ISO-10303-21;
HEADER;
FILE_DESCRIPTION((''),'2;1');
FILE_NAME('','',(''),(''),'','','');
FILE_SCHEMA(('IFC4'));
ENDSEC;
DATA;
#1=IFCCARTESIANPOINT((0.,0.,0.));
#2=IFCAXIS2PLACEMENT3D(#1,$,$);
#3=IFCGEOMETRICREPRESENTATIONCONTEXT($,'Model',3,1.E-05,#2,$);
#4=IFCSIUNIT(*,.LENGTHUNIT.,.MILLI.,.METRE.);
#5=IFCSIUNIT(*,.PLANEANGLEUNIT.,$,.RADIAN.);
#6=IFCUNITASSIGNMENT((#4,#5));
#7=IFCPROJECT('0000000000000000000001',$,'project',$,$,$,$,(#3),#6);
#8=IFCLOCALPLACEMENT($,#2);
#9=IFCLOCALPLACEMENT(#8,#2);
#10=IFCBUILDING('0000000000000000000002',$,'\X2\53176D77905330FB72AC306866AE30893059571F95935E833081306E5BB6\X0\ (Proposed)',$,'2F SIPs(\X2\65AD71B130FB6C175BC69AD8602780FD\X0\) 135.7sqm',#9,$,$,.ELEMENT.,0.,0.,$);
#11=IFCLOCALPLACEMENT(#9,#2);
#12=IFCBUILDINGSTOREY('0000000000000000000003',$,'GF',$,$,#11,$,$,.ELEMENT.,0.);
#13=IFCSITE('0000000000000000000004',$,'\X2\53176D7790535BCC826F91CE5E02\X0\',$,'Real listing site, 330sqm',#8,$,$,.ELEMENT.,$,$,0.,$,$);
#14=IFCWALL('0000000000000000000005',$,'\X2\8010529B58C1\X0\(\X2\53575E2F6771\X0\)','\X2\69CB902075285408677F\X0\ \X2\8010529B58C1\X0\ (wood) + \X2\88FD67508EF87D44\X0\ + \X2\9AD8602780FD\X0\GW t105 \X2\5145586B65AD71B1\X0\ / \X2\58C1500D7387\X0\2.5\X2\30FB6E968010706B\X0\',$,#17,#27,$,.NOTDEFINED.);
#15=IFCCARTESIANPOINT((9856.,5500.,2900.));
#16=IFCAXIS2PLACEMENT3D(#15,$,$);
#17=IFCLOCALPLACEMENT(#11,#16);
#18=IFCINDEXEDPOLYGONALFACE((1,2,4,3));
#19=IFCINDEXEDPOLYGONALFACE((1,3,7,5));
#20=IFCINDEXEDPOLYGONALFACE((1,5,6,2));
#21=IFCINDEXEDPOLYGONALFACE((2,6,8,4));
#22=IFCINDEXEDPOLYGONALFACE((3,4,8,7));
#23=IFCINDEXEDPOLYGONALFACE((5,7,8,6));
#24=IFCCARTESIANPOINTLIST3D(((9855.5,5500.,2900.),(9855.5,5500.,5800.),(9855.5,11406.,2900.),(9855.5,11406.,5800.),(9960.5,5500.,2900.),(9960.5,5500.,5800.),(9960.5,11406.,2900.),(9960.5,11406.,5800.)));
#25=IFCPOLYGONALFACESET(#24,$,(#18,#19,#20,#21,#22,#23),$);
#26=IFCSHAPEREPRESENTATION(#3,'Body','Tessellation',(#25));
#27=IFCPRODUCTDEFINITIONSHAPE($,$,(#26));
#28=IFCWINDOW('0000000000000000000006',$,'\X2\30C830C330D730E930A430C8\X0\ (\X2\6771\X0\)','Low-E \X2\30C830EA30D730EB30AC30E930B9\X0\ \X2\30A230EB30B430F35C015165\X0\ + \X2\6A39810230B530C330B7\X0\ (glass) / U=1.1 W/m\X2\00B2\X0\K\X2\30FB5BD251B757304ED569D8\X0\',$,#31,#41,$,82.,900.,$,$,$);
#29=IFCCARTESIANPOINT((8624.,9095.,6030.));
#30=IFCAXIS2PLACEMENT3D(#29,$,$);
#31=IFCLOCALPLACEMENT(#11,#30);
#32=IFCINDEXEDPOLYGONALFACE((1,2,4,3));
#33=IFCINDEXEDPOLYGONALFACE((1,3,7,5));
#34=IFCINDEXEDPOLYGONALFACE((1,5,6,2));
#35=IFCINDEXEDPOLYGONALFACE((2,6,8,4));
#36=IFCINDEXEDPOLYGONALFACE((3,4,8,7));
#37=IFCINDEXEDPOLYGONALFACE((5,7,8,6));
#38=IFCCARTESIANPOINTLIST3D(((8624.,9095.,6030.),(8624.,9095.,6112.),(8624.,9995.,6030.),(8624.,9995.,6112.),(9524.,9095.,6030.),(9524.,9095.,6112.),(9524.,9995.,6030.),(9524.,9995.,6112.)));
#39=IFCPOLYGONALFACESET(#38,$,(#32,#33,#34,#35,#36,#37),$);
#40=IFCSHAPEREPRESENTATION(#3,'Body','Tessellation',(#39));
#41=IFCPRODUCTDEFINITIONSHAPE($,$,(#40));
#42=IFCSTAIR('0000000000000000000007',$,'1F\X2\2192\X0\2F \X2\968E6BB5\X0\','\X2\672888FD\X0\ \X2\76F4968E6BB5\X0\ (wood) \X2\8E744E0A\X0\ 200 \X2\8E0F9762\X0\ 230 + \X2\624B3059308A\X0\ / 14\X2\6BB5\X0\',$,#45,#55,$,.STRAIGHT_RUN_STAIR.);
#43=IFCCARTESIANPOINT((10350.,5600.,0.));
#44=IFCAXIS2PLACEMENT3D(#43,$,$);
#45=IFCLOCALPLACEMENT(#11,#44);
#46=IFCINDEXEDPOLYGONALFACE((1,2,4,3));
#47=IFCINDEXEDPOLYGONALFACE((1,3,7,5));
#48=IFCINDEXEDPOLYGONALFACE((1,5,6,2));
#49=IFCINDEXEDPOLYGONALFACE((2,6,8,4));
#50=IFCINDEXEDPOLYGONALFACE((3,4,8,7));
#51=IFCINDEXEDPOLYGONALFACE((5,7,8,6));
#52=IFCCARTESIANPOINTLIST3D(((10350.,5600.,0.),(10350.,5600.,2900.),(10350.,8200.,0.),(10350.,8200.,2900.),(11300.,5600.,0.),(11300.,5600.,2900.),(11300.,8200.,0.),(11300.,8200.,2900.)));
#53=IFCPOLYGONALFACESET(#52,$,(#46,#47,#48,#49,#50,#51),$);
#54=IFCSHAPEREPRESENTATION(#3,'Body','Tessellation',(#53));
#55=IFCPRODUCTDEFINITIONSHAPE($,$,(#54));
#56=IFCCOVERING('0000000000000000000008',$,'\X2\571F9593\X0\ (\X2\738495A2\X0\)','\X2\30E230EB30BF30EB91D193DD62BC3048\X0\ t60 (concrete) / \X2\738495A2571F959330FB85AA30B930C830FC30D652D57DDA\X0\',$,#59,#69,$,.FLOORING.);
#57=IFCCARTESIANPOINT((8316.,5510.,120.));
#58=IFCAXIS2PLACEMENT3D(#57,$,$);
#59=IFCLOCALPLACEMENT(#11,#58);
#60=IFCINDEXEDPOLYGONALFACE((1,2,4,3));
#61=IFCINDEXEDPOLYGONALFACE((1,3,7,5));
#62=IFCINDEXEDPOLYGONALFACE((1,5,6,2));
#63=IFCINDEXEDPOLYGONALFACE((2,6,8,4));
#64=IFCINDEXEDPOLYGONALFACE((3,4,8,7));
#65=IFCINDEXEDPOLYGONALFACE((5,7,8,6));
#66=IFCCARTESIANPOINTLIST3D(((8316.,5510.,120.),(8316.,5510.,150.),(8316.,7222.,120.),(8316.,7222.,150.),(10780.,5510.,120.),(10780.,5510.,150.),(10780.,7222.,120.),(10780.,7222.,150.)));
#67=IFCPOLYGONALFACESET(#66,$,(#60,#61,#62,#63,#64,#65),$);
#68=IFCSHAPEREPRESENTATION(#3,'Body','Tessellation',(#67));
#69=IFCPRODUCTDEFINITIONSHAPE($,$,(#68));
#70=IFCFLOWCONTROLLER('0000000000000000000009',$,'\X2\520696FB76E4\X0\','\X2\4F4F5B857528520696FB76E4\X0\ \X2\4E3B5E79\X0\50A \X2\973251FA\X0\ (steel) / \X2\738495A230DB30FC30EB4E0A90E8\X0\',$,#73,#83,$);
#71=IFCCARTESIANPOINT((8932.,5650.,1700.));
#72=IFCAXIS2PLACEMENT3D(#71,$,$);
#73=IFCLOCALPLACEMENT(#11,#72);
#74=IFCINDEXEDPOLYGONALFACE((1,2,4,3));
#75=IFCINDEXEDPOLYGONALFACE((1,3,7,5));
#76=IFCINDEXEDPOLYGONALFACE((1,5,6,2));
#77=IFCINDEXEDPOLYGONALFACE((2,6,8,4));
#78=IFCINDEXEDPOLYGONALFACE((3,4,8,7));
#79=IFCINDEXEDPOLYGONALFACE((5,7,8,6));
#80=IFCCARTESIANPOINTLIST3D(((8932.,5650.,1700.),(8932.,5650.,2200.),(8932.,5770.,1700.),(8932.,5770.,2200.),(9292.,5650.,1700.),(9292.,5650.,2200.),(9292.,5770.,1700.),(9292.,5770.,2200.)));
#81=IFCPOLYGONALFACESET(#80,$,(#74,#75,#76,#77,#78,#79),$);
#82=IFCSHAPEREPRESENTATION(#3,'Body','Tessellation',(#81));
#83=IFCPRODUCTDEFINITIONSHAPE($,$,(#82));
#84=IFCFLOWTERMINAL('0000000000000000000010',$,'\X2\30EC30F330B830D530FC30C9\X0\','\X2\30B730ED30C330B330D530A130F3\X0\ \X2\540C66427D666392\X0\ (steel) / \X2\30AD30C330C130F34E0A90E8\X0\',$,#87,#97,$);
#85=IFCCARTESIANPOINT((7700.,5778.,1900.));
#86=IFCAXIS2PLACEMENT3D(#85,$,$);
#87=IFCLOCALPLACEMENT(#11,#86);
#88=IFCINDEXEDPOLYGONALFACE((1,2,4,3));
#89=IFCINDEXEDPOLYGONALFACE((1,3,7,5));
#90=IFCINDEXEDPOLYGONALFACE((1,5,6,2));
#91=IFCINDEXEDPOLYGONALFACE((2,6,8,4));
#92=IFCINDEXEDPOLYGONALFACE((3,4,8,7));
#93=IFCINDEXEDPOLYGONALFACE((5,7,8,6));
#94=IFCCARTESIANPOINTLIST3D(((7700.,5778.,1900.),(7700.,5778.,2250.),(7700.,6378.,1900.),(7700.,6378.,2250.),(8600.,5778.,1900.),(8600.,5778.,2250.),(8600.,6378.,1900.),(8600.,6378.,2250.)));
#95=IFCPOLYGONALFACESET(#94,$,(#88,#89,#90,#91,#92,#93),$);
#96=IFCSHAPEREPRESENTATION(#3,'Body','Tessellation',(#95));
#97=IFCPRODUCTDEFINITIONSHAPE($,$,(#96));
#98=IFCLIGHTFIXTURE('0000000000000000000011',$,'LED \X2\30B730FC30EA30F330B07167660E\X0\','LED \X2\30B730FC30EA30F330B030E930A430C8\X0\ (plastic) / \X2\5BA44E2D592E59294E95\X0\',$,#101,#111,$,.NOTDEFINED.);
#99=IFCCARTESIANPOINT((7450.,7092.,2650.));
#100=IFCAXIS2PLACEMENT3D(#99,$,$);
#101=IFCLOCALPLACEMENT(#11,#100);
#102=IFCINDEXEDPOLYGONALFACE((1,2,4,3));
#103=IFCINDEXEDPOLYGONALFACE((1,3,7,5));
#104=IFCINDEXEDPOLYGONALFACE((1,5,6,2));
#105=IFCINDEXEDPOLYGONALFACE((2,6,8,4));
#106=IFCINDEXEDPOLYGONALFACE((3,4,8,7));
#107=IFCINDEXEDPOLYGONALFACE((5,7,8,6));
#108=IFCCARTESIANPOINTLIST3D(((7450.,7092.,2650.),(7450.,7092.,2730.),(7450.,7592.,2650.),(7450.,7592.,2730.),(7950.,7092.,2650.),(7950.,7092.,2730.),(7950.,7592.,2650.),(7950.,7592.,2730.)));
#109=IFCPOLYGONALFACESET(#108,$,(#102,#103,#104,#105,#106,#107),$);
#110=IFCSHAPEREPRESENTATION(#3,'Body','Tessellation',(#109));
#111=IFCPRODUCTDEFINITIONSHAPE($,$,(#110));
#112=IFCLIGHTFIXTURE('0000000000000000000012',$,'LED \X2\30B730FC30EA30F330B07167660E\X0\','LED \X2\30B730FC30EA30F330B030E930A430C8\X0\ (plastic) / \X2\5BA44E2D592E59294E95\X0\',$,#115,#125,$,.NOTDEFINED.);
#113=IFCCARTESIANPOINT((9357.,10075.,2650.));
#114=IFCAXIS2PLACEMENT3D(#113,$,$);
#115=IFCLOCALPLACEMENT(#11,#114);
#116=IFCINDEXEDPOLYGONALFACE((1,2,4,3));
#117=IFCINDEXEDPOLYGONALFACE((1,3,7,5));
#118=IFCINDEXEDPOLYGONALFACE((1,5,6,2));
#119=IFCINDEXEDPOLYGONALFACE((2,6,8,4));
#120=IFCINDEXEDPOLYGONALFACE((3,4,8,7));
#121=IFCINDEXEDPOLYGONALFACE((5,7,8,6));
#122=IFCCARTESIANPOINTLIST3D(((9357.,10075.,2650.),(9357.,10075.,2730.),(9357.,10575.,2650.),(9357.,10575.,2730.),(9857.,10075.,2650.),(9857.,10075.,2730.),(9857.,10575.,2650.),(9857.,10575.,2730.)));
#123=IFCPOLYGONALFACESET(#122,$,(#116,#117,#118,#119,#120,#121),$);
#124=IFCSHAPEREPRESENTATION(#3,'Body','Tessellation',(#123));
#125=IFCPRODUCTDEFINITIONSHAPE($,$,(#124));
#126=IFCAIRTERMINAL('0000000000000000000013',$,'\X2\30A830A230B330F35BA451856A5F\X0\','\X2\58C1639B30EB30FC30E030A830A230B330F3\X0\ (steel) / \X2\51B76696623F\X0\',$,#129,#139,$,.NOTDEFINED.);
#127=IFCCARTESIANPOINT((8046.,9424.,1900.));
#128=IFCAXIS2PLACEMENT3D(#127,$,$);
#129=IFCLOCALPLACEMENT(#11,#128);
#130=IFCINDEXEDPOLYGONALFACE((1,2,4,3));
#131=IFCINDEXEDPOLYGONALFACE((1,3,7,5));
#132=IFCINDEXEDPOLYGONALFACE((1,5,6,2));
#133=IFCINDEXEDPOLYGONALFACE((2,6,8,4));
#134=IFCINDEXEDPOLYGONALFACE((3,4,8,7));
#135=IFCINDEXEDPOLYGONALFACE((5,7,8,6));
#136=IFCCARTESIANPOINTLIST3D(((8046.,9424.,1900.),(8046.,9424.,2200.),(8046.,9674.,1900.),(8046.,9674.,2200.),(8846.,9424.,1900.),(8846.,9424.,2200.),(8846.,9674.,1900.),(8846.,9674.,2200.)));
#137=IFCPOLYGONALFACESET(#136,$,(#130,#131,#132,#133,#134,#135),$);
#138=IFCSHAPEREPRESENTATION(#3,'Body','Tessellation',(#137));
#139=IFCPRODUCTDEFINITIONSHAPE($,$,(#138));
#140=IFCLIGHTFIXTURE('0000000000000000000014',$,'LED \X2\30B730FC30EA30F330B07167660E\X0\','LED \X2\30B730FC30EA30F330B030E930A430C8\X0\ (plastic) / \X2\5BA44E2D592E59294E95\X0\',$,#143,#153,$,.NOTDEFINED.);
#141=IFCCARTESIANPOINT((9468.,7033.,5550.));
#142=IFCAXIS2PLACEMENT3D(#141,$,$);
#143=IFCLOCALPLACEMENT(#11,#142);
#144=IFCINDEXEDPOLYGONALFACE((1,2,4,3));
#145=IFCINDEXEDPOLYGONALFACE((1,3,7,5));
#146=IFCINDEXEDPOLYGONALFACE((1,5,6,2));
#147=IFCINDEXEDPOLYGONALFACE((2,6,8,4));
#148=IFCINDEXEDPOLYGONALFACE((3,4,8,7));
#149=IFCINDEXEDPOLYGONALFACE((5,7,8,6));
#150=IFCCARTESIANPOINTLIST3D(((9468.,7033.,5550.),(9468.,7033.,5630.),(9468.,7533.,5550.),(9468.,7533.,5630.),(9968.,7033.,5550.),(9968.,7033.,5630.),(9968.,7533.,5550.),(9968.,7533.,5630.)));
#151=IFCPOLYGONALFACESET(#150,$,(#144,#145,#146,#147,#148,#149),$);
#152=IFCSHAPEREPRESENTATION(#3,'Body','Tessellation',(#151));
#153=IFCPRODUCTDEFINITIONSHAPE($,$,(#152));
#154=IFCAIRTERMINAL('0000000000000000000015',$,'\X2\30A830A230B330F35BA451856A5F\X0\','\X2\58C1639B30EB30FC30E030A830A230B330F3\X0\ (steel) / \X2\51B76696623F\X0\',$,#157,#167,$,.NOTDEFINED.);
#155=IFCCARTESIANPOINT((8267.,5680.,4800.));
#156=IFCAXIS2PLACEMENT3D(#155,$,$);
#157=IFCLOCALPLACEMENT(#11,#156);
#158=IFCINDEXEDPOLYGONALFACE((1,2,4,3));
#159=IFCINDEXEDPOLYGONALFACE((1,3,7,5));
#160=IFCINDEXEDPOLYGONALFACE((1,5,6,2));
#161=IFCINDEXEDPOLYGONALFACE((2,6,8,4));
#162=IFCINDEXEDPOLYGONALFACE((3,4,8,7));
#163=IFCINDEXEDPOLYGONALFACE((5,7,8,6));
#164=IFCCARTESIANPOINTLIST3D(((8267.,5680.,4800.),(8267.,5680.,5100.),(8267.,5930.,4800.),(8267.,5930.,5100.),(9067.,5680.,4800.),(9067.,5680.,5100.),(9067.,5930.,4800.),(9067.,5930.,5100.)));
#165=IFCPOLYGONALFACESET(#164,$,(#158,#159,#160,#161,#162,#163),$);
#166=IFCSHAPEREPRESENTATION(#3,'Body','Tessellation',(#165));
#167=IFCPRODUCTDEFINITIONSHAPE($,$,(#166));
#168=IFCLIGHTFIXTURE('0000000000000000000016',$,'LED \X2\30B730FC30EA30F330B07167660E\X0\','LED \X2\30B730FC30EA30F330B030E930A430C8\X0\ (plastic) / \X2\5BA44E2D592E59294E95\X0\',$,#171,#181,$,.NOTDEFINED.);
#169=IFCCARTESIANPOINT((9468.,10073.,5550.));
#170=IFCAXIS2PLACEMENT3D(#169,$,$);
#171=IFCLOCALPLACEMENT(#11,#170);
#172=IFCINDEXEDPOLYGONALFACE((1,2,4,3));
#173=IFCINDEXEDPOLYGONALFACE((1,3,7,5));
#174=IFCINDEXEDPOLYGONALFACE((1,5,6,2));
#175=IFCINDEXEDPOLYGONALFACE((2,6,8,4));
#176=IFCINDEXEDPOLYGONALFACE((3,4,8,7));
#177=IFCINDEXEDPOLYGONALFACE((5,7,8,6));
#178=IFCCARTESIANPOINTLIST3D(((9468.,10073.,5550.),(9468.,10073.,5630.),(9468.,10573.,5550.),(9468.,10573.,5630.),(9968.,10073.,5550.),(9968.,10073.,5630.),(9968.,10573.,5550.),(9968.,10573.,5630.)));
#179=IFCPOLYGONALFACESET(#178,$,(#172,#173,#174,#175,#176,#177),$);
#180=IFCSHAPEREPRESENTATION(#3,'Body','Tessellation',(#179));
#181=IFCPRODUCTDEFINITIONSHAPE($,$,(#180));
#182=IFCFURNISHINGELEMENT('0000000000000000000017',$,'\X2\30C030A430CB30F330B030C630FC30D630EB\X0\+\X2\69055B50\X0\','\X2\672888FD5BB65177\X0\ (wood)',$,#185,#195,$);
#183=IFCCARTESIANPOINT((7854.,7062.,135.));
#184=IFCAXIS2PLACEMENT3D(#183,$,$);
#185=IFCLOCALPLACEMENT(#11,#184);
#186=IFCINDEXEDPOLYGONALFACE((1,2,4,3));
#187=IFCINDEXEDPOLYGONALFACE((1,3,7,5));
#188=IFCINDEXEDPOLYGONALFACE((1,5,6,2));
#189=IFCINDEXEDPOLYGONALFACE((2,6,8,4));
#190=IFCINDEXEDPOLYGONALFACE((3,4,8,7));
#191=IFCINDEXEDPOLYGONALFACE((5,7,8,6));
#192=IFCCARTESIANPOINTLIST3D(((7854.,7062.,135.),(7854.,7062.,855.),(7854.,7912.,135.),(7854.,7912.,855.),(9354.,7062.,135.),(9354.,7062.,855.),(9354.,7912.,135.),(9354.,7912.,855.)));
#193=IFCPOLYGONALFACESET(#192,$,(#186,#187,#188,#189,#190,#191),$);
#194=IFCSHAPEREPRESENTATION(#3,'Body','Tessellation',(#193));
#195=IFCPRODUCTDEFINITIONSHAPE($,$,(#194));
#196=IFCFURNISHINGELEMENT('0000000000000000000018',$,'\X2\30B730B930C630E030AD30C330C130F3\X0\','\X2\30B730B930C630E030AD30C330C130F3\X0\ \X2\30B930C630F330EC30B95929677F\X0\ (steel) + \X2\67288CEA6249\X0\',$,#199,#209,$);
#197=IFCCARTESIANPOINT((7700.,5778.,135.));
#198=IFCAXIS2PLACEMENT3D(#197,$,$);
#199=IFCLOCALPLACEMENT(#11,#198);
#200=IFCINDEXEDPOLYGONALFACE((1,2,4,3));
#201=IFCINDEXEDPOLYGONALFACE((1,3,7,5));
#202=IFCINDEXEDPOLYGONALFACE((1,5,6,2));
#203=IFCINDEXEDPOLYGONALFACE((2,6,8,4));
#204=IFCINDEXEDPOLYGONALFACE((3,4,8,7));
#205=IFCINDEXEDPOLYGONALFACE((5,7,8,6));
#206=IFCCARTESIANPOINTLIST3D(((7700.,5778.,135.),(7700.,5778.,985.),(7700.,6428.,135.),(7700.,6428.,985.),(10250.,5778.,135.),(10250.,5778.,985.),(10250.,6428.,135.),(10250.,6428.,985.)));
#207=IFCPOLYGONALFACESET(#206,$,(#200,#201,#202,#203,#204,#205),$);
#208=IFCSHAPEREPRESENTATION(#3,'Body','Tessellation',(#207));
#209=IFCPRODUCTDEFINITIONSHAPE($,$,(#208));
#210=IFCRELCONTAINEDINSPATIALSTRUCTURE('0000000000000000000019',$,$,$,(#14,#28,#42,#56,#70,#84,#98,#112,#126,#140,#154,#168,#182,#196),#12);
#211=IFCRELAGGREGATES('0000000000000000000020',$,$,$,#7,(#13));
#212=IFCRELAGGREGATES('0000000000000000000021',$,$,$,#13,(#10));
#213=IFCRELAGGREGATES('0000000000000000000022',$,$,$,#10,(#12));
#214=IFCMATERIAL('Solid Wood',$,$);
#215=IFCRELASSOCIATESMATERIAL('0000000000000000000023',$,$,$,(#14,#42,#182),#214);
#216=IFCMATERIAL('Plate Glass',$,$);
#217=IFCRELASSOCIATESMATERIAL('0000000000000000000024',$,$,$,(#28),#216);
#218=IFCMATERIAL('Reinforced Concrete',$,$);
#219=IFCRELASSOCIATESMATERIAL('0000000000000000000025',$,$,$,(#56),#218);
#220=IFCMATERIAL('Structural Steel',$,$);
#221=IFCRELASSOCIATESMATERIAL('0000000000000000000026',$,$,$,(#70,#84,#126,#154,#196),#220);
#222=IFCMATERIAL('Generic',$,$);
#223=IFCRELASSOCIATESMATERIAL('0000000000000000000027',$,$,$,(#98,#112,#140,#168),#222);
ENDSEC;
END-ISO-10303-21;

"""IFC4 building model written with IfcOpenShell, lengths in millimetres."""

from ifc_helpers import new_model, si_unit, frame, frame_2d, origin, place, context, project, spatial, rectangle, extrude, material, element, save


model = new_model("IFC4")

# Units and contexts
model_context = context("Model", 3, precision=1e-05, world=origin())
ifc_project = project(units=[si_unit("LENGTHUNIT", "METRE", prefix="MILLI"), si_unit("PLANEANGLEUNIT", "RADIAN")], contexts=[model_context])

# Site, building, storey
site_placement = place(None, origin())
site = spatial("IfcSite", under=ifc_project, at=site_placement, Name="北海道富良野市", ObjectType="Real listing site, 330sqm", CompositionType="ELEMENT", RefElevation=0.0)
building_placement = place(site_placement, origin())
building = spatial("IfcBuilding", under=site, at=building_placement, Name="北海道・犬と暮らす土間広めの家 (Proposed)", ObjectType="2F SIPs(断熱・気密高性能) 135.7sqm", CompositionType="ELEMENT", ElevationOfRefHeight=0.0, ElevationOfTerrain=0.0)
storey_placement = place(building_placement, origin())
storey = spatial("IfcBuildingStorey", under=building, at=storey_placement, Name="GF", CompositionType="ELEMENT", Elevation=0.0)

# Shared definitions
ifc_material_1 = material(Name="Solid Wood")

# Wall
wall_1_placement = place(storey_placement, frame((9856.0, 5500.0, 2900.0)))
element("IfcWall", 1, at=wall_1_placement, inside=storey, material=ifc_material_1, Name="耐力壁(南帯東)", Description="構造用合板 耐力壁 (wood) + 製材軸組 + 高性能GW t105 充填断熱 / 壁倍率2.5・準耐火", PredefinedType="NOTDEFINED", context=model_context, shape_type="SweptSolid", body=[
    extrude(rectangle(XDim=105.0, YDim=5906.0, at=frame_2d((52.0, 2953.0))), frame((9856.0, 5500.0, 2900.0)), (0.0, 0.0, 1.0), 2900.0),
])

# Window
ifc_material_2 = material(Name="Plate Glass")
window_placement = place(storey_placement, frame((8624.0, 9095.0, 6030.0)))
element("IfcWindow", 2, at=window_placement, inside=storey, material=ifc_material_2, Name="トップライト (東)", Description="Low-E トリプルガラス アルゴン封入 + 樹脂サッシ (glass) / U=1.1 W/m²K・寒冷地仕様", OverallHeight=82.0, OverallWidth=900.0, context=model_context, shape_type="SweptSolid", body=[
    extrude(rectangle(XDim=900.0, YDim=900.0, at=frame_2d((450.0, 450.0))), frame((8624.0, 9095.0, 6030.0)), (0.0, 0.0, 1.0), 82.0),
])

# Stair
stair_placement = place(storey_placement, frame((10350.0, 5600.0, 0.0)))
element("IfcStair", 3, at=stair_placement, inside=storey, material=ifc_material_1, Name="1F→2F 階段", Description="木製 直階段 (wood) 蹴上 200 踏面 230 + 手すり / 14段", PredefinedType="STRAIGHT_RUN_STAIR", context=model_context, shape_type="SweptSolid", body=[
    extrude(rectangle(XDim=950.0, YDim=2600.0, at=frame_2d((475.0, 1300.0))), frame((10350.0, 5600.0, 0.0)), (0.0, 0.0, 1.0), 2900.0),
])

# Covering
ifc_material_3 = material(Name="Reinforced Concrete")
covering_placement = place(storey_placement, frame((8316.0, 5510.0, 120.0)))
element("IfcCovering", 4, at=covering_placement, inside=storey, material=ifc_material_3, Name="土間 (玄関)", Description="モルタル金鏝押え t60 (concrete) / 玄関土間・薪ストーブ動線", PredefinedType="FLOORING", context=model_context, shape_type="SweptSolid", body=[
    extrude(rectangle(XDim=2464.0, YDim=1712.0, at=frame_2d((1232.0, 856.0))), frame((8316.0, 5510.0, 120.0)), (0.0, 0.0, 1.0), 30.0),
])

# Flow controller
ifc_material_4 = material(Name="Structural Steel")
flow_controller_placement = place(storey_placement, frame((8932.0, 5650.0, 1700.0)))
element("IfcFlowController", 5, at=flow_controller_placement, inside=storey, material=ifc_material_4, Name="分電盤", Description="住宅用分電盤 主幹50A 露出 (steel) / 玄関ホール上部", context=model_context, shape_type="SweptSolid", body=[
    extrude(rectangle(XDim=360.0, YDim=120.0, at=frame_2d((180.0, 60.0))), frame((8932.0, 5650.0, 1700.0)), (0.0, 0.0, 1.0), 500.0),
])

# Flow terminal
flow_terminal_placement = place(storey_placement, frame((7700.0, 5778.0, 1900.0)))
element("IfcFlowTerminal", 6, at=flow_terminal_placement, inside=storey, material=ifc_material_4, Name="レンジフード", Description="シロッコファン 同時給排 (steel) / キッチン上部", context=model_context, shape_type="SweptSolid", body=[
    extrude(rectangle(XDim=900.0, YDim=600.0, at=frame_2d((450.0, 300.0))), frame((7700.0, 5778.0, 1900.0)), (0.0, 0.0, 1.0), 350.0),
])

# Light fixtures
ifc_material_5 = material(Name="Generic")
light_fixture_1_placement = place(storey_placement, frame((7450.0, 7092.0, 2650.0)))
element("IfcLightFixture", 7, at=light_fixture_1_placement, inside=storey, material=ifc_material_5, Name="LED シーリング照明", Description="LED シーリングライト (plastic) / 室中央天井", PredefinedType="NOTDEFINED", context=model_context, shape_type="SweptSolid", body=[
    extrude(rectangle(XDim=500.0, YDim=500.0, at=frame_2d((250.0, 250.0))), frame((7450.0, 7092.0, 2650.0)), (0.0, 0.0, 1.0), 80.0),
])
light_fixture_2_placement = place(storey_placement, frame((9357.0, 10075.0, 2650.0)))
element("IfcLightFixture", 8, at=light_fixture_2_placement, inside=storey, material=ifc_material_5, Name="LED シーリング照明", Description="LED シーリングライト (plastic) / 室中央天井", PredefinedType="NOTDEFINED", context=model_context, shape_type="SweptSolid", body=[
    extrude(rectangle(XDim=500.0, YDim=500.0, at=frame_2d((250.0, 250.0))), frame((9357.0, 10075.0, 2650.0)), (0.0, 0.0, 1.0), 80.0),
])

# Air terminal
air_terminal_1_placement = place(storey_placement, frame((8046.0, 9424.0, 1900.0)))
element("IfcAirTerminal", 9, at=air_terminal_1_placement, inside=storey, material=ifc_material_4, Name="エアコン室内機", Description="壁掛ルームエアコン (steel) / 冷暖房", PredefinedType="NOTDEFINED", context=model_context, shape_type="SweptSolid", body=[
    extrude(rectangle(XDim=800.0, YDim=250.0, at=frame_2d((400.0, 125.0))), frame((8046.0, 9424.0, 1900.0)), (0.0, 0.0, 1.0), 300.0),
])

# Light fixture
light_fixture_3_placement = place(storey_placement, frame((9468.0, 7033.0, 5550.0)))
element("IfcLightFixture", 10, at=light_fixture_3_placement, inside=storey, material=ifc_material_5, Name="LED シーリング照明", Description="LED シーリングライト (plastic) / 室中央天井", PredefinedType="NOTDEFINED", context=model_context, shape_type="SweptSolid", body=[
    extrude(rectangle(XDim=500.0, YDim=500.0, at=frame_2d((250.0, 250.0))), frame((9468.0, 7033.0, 5550.0)), (0.0, 0.0, 1.0), 80.0),
])

# Air terminal
air_terminal_2_placement = place(storey_placement, frame((8267.0, 5680.0, 4800.0)))
element("IfcAirTerminal", 11, at=air_terminal_2_placement, inside=storey, material=ifc_material_4, Name="エアコン室内機", Description="壁掛ルームエアコン (steel) / 冷暖房", PredefinedType="NOTDEFINED", context=model_context, shape_type="SweptSolid", body=[
    extrude(rectangle(XDim=800.0, YDim=250.0, at=frame_2d((400.0, 125.0))), frame((8267.0, 5680.0, 4800.0)), (0.0, 0.0, 1.0), 300.0),
])

# Light fixture
light_fixture_4_placement = place(storey_placement, frame((9468.0, 10073.0, 5550.0)))
element("IfcLightFixture", 12, at=light_fixture_4_placement, inside=storey, material=ifc_material_5, Name="LED シーリング照明", Description="LED シーリングライト (plastic) / 室中央天井", PredefinedType="NOTDEFINED", context=model_context, shape_type="SweptSolid", body=[
    extrude(rectangle(XDim=500.0, YDim=500.0, at=frame_2d((250.0, 250.0))), frame((9468.0, 10073.0, 5550.0)), (0.0, 0.0, 1.0), 80.0),
])

# Furnishing elements
furnishing_1_placement = place(storey_placement, frame((7854.0, 7062.0, 135.0)))
element("IfcFurnishingElement", 13, at=furnishing_1_placement, inside=storey, material=ifc_material_1, Name="ダイニングテーブル+椅子", Description="木製家具 (wood)", context=model_context, shape_type="SweptSolid", body=[
    extrude(rectangle(XDim=1500.0, YDim=850.0, at=frame_2d((750.0, 425.0))), frame((7854.0, 7062.0, 135.0)), (0.0, 0.0, 1.0), 720.0),
])
furnishing_2_placement = place(storey_placement, frame((7700.0, 5778.0, 135.0)))
element("IfcFurnishingElement", 14, at=furnishing_2_placement, inside=storey, material=ifc_material_4, Name="システムキッチン", Description="システムキッチン ステンレス天板 (steel) + 木質扉", context=model_context, shape_type="SweptSolid", body=[
    extrude(rectangle(XDim=2550.0, YDim=650.0, at=frame_2d((1275.0, 325.0))), frame((7700.0, 5778.0, 135.0)), (0.0, 0.0, 1.0), 850.0),
])

save(model, "model.ifc")
